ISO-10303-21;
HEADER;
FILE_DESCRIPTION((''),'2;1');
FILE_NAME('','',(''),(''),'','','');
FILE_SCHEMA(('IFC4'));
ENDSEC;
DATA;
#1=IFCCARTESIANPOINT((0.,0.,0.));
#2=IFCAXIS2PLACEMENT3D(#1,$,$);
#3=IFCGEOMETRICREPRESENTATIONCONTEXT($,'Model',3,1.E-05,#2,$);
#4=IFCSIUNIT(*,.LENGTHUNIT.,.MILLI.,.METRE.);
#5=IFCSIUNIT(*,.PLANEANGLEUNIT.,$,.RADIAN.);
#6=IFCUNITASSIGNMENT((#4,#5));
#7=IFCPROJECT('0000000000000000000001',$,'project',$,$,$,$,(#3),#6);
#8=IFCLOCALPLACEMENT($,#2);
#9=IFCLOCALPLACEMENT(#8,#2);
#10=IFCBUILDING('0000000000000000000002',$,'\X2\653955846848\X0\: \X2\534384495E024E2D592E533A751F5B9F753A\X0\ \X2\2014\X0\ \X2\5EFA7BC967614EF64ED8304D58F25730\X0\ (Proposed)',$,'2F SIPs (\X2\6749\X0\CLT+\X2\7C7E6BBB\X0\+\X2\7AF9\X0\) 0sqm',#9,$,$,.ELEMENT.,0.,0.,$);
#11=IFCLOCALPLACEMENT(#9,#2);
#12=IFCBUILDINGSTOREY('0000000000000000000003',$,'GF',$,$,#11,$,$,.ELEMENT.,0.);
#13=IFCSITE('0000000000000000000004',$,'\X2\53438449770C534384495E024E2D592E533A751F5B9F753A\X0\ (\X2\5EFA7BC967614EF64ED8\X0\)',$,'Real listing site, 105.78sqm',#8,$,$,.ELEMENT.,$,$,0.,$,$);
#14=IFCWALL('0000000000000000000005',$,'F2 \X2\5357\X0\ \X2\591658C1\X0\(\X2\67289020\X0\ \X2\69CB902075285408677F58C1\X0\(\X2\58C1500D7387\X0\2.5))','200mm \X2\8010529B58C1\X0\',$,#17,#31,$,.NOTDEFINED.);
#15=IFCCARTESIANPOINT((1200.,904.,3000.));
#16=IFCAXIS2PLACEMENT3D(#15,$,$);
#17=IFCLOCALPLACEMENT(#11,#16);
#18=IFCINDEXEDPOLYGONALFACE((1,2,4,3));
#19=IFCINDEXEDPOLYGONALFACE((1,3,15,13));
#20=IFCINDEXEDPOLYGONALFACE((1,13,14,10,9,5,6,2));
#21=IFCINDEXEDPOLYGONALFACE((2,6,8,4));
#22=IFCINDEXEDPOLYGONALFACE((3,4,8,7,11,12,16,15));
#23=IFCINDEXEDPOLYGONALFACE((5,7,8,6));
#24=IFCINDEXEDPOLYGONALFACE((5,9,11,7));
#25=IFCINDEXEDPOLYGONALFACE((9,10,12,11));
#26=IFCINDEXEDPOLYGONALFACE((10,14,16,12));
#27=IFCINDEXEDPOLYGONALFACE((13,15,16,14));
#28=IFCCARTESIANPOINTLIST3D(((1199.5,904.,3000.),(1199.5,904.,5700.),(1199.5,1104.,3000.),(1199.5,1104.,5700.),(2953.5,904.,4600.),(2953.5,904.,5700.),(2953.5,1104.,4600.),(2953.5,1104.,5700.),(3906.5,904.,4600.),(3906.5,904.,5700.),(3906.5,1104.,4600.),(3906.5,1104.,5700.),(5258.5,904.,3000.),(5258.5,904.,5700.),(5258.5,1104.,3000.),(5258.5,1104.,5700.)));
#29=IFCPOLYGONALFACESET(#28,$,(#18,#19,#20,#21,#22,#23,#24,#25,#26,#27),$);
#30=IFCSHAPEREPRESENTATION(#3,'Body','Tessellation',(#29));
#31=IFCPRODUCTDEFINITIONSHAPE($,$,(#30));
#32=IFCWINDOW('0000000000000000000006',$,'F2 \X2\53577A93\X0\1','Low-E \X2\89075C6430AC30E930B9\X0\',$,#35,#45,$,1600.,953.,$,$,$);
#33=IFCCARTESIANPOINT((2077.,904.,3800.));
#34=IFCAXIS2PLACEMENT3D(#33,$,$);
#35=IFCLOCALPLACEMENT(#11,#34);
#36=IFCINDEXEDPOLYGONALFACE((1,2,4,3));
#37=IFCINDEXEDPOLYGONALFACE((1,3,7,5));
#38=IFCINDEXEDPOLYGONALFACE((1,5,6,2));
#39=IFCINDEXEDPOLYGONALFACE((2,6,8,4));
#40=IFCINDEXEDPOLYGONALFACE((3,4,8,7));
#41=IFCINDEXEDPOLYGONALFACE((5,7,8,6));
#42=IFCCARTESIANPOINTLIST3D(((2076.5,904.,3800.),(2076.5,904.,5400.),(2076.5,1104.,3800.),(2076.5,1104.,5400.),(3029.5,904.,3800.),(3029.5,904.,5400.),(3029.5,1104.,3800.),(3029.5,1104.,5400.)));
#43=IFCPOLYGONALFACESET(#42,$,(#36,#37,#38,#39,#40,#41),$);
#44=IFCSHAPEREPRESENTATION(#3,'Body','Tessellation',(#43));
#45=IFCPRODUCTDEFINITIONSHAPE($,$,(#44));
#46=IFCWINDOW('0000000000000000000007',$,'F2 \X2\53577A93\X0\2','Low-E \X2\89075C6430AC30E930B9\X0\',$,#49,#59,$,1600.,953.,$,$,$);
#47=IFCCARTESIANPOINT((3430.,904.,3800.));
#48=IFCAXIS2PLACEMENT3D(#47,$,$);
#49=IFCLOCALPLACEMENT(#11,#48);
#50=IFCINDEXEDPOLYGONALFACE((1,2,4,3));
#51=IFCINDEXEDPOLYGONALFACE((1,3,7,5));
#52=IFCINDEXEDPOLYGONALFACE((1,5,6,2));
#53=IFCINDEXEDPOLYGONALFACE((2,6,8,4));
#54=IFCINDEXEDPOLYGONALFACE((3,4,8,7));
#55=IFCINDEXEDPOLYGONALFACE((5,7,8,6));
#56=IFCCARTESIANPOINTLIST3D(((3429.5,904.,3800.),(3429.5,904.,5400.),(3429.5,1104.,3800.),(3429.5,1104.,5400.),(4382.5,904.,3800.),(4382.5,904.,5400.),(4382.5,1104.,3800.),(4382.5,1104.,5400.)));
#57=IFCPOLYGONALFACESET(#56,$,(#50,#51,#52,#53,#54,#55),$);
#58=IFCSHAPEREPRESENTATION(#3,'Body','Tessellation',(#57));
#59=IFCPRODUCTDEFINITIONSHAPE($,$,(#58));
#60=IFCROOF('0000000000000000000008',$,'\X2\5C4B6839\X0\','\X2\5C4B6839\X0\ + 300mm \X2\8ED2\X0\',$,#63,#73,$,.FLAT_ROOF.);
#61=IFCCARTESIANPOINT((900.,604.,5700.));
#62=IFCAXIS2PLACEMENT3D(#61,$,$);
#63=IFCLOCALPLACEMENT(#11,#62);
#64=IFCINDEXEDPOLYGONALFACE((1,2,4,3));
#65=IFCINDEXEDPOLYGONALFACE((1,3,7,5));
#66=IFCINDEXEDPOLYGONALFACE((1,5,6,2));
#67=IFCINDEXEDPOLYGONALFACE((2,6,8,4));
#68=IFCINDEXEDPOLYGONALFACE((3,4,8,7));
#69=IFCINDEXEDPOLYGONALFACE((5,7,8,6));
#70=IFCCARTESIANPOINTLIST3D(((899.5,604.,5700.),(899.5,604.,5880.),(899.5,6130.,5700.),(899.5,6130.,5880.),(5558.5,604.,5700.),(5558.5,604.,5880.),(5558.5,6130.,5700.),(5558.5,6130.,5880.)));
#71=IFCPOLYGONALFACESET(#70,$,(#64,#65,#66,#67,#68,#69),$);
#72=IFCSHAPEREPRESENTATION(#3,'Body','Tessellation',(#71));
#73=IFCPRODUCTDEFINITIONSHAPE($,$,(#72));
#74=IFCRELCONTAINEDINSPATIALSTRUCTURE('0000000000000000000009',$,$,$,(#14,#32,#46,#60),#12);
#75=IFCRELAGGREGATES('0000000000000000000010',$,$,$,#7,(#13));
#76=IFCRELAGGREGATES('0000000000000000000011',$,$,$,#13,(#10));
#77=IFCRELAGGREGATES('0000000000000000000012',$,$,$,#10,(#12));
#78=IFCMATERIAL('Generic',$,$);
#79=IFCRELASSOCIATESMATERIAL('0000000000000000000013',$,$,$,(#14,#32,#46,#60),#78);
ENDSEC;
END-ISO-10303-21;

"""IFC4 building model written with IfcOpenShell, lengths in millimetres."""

from ifc_helpers import new_model, si_unit, frame, frame_2d, origin, place, context, project, spatial, rectangle, extrude, material, element, fill, save


model = new_model("IFC4")

# Units and contexts
model_context = context("Model", 3, precision=1e-05, world=origin())
ifc_project = project(units=[si_unit("LENGTHUNIT", "METRE", prefix="MILLI"), si_unit("PLANEANGLEUNIT", "RADIAN")], contexts=[model_context])

# Site, building, storey
site_placement = place(None, origin())
site = spatial("IfcSite", under=ifc_project, at=site_placement, Name="千葉県千葉市中央区生実町 (建築条件付)", ObjectType="Real listing site, 105.78sqm", CompositionType="ELEMENT", RefElevation=0.0)
building_placement = place(site_placement, origin())
building = spatial("IfcBuilding", under=site, at=building_placement, Name="改善案: 千葉市中央区生実町 — 建築条件付き売地 (Proposed)", ObjectType="2F SIPs (杉CLT+籾殻+竹) 0sqm", CompositionType="ELEMENT", ElevationOfRefHeight=0.0, ElevationOfTerrain=0.0)
storey_placement = place(building_placement, origin())
storey = spatial("IfcBuildingStorey", under=building, at=storey_placement, Name="GF", CompositionType="ELEMENT", Elevation=0.0)

# Shared definitions
ifc_material_1 = material(Name="Generic")

# Wall, openings, windows
wall_1_placement = place(storey_placement, frame((1200.0, 904.0, 3000.0)))
wall_1 = element("IfcWall", 1, at=wall_1_placement, inside=storey, material=ifc_material_1, Name="F2 南 外壁(木造 構造用合板壁(壁倍率2.5))", Description="200mm 耐力壁", PredefinedType="NOTDEFINED", context=model_context, shape_type="SweptSolid", body=[
    extrude(rectangle(XDim=4059.0, YDim=200.0, at=frame_2d((2029.0, 100.0))), frame((1200.0, 904.0, 3000.0)), (0.0, 0.0, 1.0), 2700.0),
])
opening_1_placement = place(storey_placement, frame((2077.0, 904.0, 3800.0)))
opening_1 = element("IfcOpeningElement", 2, at=opening_1_placement, cuts=wall_1, PredefinedType="NOTDEFINED", context=model_context, shape_type="SweptSolid", body=[
    extrude(rectangle(XDim=953.0, YDim=200.0, at=frame_2d((476.0, 100.0))), frame((2077.0, 904.0, 3800.0)), (0.0, 0.0, 1.0), 1600.0),
])
opening_2_placement = place(storey_placement, frame((3430.0, 904.0, 3800.0)))
opening_2 = element("IfcOpeningElement", 3, at=opening_2_placement, cuts=wall_1, PredefinedType="NOTDEFINED", context=model_context, shape_type="SweptSolid", body=[
    extrude(rectangle(XDim=953.0, YDim=200.0, at=frame_2d((476.0, 100.0))), frame((3430.0, 904.0, 3800.0)), (0.0, 0.0, 1.0), 1600.0),
])
window_1_placement = place(storey_placement, frame((2077.0, 904.0, 3800.0)))
window_1 = element("IfcWindow", 4, at=window_1_placement, inside=storey, material=ifc_material_1, Name="F2 南窓1", Description="Low-E 複層ガラス", OverallHeight=1600.0, OverallWidth=953.0, context=model_context, shape_type="SweptSolid", body=[
    extrude(rectangle(XDim=953.0, YDim=200.0, at=frame_2d((476.0, 100.0))), frame((2077.0, 904.0, 3800.0)), (0.0, 0.0, 1.0), 1600.0),
])
fill(opening_1, window_1)
window_2_placement = place(storey_placement, frame((3430.0, 904.0, 3800.0)))
window_2 = element("IfcWindow", 5, at=window_2_placement, inside=storey, material=ifc_material_1, Name="F2 南窓2", Description="Low-E 複層ガラス", OverallHeight=1600.0, OverallWidth=953.0, context=model_context, shape_type="SweptSolid", body=[
    extrude(rectangle(XDim=953.0, YDim=200.0, at=frame_2d((476.0, 100.0))), frame((3430.0, 904.0, 3800.0)), (0.0, 0.0, 1.0), 1600.0),
])
fill(opening_2, window_2)

# Roof
roof_placement = place(storey_placement, frame((900.0, 604.0, 5700.0)))
element("IfcRoof", 6, at=roof_placement, inside=storey, material=ifc_material_1, Name="屋根", Description="屋根 + 300mm 軒", PredefinedType="FLAT_ROOF", context=model_context, shape_type="SweptSolid", body=[
    extrude(rectangle(XDim=4659.0, YDim=5526.0, at=frame_2d((2329.0, 2763.0))), frame((900.0, 604.0, 5700.0)), (0.0, 0.0, 1.0), 180.0),
])

save(model, "model.ifc")
